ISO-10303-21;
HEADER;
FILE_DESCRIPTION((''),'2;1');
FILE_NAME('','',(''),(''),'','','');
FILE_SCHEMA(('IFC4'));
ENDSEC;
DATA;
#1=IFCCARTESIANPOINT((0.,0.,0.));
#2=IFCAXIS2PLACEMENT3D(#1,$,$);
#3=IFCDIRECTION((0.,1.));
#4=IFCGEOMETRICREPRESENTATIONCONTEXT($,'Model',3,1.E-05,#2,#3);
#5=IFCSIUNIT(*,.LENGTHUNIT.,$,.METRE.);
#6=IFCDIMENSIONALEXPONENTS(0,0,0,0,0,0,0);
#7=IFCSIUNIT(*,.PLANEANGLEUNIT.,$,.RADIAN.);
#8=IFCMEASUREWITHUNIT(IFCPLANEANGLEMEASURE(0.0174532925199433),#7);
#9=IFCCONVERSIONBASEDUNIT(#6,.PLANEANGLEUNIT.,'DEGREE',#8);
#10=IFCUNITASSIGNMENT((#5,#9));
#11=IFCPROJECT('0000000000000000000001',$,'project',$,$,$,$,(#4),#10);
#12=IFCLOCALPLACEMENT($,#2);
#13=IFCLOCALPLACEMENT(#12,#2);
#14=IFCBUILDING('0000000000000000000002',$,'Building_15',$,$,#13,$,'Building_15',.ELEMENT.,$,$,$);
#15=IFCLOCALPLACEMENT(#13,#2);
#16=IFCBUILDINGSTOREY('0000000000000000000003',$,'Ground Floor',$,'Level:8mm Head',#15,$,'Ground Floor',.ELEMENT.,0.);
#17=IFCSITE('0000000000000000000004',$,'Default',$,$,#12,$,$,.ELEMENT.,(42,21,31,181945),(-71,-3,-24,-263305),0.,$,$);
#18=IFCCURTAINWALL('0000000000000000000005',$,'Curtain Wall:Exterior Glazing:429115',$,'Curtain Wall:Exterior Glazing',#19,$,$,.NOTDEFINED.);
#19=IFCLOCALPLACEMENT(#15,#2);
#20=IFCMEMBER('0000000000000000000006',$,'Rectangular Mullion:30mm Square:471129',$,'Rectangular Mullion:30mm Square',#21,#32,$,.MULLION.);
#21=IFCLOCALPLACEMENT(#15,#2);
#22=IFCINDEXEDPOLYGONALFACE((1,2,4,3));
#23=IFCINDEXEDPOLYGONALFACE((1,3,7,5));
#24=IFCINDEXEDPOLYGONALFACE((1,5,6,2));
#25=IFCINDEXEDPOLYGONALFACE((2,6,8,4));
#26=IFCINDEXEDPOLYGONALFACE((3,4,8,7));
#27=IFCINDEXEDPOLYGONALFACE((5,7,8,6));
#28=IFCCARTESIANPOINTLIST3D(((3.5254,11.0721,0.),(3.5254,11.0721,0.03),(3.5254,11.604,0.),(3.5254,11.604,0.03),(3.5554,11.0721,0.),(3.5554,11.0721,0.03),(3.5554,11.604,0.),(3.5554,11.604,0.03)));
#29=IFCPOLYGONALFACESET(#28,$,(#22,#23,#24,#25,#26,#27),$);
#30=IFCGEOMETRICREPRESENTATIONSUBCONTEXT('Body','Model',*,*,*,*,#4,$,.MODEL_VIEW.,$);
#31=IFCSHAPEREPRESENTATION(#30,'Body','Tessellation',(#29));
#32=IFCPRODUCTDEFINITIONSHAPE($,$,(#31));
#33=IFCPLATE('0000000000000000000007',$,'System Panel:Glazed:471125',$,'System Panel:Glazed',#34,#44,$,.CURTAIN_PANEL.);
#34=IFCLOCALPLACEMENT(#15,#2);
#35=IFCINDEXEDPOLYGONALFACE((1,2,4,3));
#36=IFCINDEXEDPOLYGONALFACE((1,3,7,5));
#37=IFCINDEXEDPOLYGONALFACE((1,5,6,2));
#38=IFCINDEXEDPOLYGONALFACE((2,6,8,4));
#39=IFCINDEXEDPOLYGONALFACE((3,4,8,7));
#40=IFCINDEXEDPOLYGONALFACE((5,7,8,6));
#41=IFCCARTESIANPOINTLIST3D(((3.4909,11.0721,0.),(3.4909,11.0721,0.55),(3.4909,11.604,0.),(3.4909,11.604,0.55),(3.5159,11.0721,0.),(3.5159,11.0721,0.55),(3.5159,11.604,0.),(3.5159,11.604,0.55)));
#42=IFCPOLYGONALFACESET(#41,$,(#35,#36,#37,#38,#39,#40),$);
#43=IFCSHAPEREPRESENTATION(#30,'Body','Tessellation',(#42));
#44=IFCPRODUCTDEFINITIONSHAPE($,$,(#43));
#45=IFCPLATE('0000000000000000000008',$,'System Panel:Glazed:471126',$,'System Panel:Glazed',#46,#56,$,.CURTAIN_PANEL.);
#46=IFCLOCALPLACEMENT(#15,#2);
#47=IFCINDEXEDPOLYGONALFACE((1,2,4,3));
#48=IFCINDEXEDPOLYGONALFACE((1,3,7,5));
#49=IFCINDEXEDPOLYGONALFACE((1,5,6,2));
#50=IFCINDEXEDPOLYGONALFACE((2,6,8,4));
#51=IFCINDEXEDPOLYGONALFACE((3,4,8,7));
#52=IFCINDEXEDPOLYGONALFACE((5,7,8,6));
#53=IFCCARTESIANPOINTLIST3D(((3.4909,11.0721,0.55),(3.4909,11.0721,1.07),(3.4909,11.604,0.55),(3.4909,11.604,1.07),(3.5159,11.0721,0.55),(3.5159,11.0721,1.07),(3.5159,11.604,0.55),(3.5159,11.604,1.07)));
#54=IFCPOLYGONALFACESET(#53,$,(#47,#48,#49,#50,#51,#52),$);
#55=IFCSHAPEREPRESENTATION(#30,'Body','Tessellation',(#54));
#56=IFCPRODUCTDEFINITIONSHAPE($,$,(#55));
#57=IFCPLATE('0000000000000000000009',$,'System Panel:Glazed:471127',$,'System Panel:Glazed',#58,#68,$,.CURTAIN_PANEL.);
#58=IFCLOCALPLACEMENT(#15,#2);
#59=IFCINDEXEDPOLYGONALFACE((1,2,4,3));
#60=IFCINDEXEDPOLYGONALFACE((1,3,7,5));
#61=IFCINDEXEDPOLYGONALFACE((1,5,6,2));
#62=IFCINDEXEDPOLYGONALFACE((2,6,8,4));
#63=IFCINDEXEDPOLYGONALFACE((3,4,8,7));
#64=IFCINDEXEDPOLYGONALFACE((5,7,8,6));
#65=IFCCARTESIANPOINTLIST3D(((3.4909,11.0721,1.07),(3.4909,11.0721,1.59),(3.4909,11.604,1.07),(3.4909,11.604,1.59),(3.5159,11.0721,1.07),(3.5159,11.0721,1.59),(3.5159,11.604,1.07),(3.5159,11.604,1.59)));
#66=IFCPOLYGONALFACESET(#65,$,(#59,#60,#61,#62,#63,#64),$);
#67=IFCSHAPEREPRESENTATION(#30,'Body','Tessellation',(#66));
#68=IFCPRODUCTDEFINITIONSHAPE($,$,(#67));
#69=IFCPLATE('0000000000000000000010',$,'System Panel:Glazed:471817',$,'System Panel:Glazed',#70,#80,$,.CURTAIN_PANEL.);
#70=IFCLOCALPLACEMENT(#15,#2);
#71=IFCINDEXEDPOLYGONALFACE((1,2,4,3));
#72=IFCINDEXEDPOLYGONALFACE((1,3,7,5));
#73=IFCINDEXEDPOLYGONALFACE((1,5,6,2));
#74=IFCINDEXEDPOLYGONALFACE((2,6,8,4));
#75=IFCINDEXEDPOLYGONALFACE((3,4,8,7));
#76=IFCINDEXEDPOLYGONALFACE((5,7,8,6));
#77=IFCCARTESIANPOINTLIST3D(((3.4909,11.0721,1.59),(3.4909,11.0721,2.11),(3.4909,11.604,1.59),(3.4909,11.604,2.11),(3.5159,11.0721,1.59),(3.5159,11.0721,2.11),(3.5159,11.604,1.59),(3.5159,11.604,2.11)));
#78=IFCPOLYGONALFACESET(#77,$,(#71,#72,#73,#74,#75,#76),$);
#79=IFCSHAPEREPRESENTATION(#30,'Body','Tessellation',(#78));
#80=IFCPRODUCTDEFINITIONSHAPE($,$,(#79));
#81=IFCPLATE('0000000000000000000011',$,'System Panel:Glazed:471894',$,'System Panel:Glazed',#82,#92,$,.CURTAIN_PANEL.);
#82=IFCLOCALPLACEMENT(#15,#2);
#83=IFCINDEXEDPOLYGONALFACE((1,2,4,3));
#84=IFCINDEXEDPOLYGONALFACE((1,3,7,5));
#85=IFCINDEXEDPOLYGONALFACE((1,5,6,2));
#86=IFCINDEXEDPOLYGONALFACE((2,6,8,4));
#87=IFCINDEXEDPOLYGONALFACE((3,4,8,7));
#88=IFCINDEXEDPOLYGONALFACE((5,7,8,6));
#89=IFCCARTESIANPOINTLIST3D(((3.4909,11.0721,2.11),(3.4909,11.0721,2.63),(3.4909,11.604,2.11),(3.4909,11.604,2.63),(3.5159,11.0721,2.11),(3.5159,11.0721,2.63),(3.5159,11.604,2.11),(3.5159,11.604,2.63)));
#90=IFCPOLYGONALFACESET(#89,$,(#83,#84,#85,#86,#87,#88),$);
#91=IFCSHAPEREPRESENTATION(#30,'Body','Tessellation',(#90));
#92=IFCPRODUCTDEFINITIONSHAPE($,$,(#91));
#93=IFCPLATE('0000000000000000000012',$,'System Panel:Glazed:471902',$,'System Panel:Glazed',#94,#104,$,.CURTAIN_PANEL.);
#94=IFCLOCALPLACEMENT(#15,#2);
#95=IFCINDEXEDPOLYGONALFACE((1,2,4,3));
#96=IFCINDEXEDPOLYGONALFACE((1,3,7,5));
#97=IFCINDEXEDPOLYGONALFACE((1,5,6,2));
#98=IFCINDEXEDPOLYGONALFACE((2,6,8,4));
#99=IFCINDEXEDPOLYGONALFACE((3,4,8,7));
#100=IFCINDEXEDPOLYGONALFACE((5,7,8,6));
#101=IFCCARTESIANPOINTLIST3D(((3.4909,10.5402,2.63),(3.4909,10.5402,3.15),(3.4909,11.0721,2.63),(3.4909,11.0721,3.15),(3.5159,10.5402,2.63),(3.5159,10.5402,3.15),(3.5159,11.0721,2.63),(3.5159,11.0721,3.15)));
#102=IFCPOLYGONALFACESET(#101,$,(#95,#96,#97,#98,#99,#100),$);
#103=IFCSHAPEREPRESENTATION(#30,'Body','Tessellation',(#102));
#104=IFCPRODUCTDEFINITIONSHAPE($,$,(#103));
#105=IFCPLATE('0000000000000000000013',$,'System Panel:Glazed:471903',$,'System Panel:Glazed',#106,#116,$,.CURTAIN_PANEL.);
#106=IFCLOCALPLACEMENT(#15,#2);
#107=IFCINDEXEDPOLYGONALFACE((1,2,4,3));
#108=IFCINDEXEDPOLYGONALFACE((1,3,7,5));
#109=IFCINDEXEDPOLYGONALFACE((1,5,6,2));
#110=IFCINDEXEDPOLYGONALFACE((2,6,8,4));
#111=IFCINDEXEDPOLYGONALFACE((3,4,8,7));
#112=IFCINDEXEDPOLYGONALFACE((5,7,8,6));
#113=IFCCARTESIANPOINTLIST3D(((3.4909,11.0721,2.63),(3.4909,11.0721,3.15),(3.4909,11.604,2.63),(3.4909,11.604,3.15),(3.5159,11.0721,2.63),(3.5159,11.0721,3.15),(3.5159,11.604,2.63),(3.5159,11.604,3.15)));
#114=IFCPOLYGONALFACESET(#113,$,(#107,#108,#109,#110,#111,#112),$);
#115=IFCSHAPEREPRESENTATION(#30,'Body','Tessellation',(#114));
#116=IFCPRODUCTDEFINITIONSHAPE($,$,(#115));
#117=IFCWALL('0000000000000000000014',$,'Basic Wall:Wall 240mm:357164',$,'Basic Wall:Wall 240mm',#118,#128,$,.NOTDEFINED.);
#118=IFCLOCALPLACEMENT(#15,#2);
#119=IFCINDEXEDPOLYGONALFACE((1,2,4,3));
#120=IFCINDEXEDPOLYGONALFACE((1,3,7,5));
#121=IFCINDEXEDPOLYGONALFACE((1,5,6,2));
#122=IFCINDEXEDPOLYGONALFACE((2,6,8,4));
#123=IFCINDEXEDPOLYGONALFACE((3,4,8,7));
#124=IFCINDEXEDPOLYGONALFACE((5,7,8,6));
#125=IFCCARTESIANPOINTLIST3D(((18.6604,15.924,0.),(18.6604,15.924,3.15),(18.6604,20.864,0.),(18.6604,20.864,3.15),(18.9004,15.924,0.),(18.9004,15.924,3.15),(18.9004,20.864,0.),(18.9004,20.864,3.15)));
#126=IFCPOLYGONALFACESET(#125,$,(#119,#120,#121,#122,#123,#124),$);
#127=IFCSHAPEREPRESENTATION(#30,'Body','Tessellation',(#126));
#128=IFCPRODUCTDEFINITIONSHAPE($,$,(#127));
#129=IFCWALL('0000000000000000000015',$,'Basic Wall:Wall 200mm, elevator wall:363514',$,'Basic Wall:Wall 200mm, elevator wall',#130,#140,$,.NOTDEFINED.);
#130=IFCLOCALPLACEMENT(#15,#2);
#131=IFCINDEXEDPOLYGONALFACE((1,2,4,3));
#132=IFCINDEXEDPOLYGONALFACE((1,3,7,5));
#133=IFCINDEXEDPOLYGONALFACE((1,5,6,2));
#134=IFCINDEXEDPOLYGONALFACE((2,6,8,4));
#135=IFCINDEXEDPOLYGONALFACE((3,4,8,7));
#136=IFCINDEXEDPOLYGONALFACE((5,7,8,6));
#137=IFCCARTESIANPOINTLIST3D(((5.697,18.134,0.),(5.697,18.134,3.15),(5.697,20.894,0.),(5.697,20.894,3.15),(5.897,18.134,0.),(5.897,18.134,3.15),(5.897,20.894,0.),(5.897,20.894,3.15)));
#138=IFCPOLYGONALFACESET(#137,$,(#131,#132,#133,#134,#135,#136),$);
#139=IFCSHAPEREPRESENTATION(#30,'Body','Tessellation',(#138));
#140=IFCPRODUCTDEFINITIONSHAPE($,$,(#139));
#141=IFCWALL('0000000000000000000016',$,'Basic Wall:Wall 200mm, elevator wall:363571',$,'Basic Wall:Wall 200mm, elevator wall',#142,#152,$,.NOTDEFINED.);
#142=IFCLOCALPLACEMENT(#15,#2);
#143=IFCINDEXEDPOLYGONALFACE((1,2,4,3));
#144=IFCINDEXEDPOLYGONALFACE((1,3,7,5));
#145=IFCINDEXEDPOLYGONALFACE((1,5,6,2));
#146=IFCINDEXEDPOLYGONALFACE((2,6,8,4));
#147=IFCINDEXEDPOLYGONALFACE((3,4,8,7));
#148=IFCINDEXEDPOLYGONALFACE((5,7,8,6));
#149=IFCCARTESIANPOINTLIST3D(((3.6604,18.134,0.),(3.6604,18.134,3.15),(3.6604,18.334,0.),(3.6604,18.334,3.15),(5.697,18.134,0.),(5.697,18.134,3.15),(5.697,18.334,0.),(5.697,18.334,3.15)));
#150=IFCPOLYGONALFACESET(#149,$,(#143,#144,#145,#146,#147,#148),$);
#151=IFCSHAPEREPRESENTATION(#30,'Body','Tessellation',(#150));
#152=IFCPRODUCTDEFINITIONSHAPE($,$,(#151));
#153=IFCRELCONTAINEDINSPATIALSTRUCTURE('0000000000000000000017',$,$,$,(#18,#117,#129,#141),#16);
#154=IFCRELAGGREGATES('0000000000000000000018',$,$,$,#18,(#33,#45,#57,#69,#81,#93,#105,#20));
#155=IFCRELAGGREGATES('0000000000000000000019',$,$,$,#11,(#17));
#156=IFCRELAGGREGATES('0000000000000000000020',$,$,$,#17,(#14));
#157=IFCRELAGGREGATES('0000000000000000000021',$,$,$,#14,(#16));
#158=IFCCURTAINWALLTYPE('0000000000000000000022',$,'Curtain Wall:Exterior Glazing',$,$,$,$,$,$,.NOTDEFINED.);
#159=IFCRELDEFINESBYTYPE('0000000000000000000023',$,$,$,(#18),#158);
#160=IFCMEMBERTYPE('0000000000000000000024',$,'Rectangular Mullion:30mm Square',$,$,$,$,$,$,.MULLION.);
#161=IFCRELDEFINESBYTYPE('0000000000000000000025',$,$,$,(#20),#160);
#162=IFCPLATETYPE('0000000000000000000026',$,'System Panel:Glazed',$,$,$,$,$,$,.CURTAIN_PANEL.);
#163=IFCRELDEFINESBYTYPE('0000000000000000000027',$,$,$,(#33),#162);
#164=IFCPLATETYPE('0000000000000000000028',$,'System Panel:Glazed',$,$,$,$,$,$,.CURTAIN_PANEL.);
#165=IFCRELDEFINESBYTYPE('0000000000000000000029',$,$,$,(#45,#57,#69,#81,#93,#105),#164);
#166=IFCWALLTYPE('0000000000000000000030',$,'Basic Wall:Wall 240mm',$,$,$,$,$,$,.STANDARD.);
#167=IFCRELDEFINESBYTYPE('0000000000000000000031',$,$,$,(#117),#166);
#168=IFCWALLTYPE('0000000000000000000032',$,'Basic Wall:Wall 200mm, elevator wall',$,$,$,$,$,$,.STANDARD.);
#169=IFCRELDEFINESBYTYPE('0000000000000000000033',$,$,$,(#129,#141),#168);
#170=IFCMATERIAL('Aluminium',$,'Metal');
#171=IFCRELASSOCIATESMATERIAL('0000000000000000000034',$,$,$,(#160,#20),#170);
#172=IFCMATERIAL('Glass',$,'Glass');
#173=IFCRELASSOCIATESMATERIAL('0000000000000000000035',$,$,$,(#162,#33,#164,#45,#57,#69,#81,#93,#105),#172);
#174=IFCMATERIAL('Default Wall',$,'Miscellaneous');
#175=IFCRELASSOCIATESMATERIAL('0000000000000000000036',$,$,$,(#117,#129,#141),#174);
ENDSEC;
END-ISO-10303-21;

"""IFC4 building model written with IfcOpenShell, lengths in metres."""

from ifc_helpers import new_model, entity, si_unit, converted_unit, direction, frame, origin, place, context, subcontext, project, spatial, indexed_curve, outline, extrude, source, transform, mapped, material, type_object, type_shapes, element, aggregate, save


model = new_model("IFC4")

# Units and contexts
model_context = context("Model", 3, precision=1e-05, world=origin(), true_north=direction((0.0, 1.0)))
body_context = subcontext(model_context, "Body", "Model", "MODEL_VIEW")
ifc_project = project(units=[si_unit("LENGTHUNIT", "METRE"), converted_unit("PLANEANGLEUNIT", "DEGREE", entity("IfcPlaneAngleMeasure", 0.0174532925199433), si_unit("PLANEANGLEUNIT", "RADIAN"), dimensions=[0, 0, 0, 0, 0, 0, 0])], contexts=[model_context])

# Site, building, storey
site_placement = place(None, origin())
site = spatial("IfcSite", under=ifc_project, at=site_placement, Name="Default", CompositionType="ELEMENT", RefLatitude=(42, 21, 31, 181945), RefLongitude=(-71, -3, -24, -263305), RefElevation=0.0)
building_placement = place(site_placement, origin())
building = spatial("IfcBuilding", under=site, at=building_placement, Name="Building_15", LongName="Building_15", CompositionType="ELEMENT")
storey_placement = place(building_placement, origin())
storey = spatial("IfcBuildingStorey", under=building, at=storey_placement, Name="Ground Floor", ObjectType="Level:8mm Head", LongName="Ground Floor", CompositionType="ELEMENT", Elevation=0.0)

# Curtain wall, member, plates
curtain_wall_type = type_object("IfcCurtainWallType", Name="Curtain Wall:Exterior Glazing", PredefinedType="NOTDEFINED")
curtain_wall_placement = place(storey_placement, origin())
curtain_wall = element("IfcCurtainWall", 1, at=curtain_wall_placement, inside=storey, type_object=curtain_wall_type, Name="Curtain Wall:Exterior Glazing:429115", ObjectType="Curtain Wall:Exterior Glazing", PredefinedType="NOTDEFINED")
ifc_material_1 = material(Name="Aluminium", Category="Metal")
member_type = type_object("IfcMemberType", Name="Rectangular Mullion:30mm Square", PredefinedType="MULLION", material=ifc_material_1)
shared_shape_1 = source(origin(), body_context, "Body", "SweptSolid", [
    extrude(outline(indexed_curve([(-0.015, -0.015), (0.015, -0.015), (0.015, 0.015), (-0.015, 0.015), (-0.015, -0.015)], self_intersect=False)), frame((-0.015, 0.0, -0.5319), z_axis=(0.0, 0.0, 1.0), x_axis=(-1.0, 0.0, 0.0)), (0.0, 0.0, 1.0), 0.5319),
])
type_shapes(member_type, [shared_shape_1])
member_placement = place(curtain_wall_placement, frame((3.5404, 11.0721, 0.0), z_axis=(0.0, -1.0, 0.0), x_axis=(0.0, 0.0, -1.0)))
member = element("IfcMember", 2, at=member_placement, type_object=member_type, material=ifc_material_1, Name="Rectangular Mullion:30mm Square:471129", ObjectType="Rectangular Mullion:30mm Square", PredefinedType="MULLION", context=body_context, shape_type="MappedRepresentation", body=[
    mapped(shared_shape_1, transform((0.0, 0.0, 0.0), scale=1.0)),
])
ifc_material_2 = material(Name="Glass", Category="Glass")
plate_type_1 = type_object("IfcPlateType", Name="System Panel:Glazed", PredefinedType="CURTAIN_PANEL", material=ifc_material_2)
shared_shape_2 = source(origin(), body_context, "Body", "SweptSolid", [
    extrude(outline(indexed_curve([(-0.0125, -0.2659), (0.0125, -0.2659), (0.0125, 0.2659), (-0.0125, 0.2659), (-0.0125, -0.2659)], self_intersect=False)), frame((0.0, 0.037, 0.0), z_axis=(0.0, 0.0, 1.0), x_axis=(0.0, 1.0, 0.0)), (0.0, 0.0, 1.0), 0.55),
])
type_shapes(plate_type_1, [shared_shape_2])
plate_1_placement = place(curtain_wall_placement, frame((3.5404, 11.3381, 0.0), z_axis=(0.0, 0.0, 1.0), x_axis=(0.0, 1.0, 0.0)))
plate_1 = element("IfcPlate", 3, at=plate_1_placement, type_object=plate_type_1, material=ifc_material_2, Name="System Panel:Glazed:471125", ObjectType="System Panel:Glazed", PredefinedType="CURTAIN_PANEL", context=body_context, shape_type="MappedRepresentation", body=[
    mapped(shared_shape_2, transform((0.0, 0.0, 0.0), scale=1.0)),
])
plate_type_2 = type_object("IfcPlateType", Name="System Panel:Glazed", PredefinedType="CURTAIN_PANEL", material=ifc_material_2)
shared_shape_3 = source(origin(), body_context, "Body", "SweptSolid", [
    extrude(outline(indexed_curve([(-0.0125, -0.2659), (0.0125, -0.2659), (0.0125, 0.2659), (-0.0125, 0.2659), (-0.0125, -0.2659)], self_intersect=False)), frame((0.0, 0.037, 0.0), z_axis=(0.0, 0.0, 1.0), x_axis=(0.0, 1.0, 0.0)), (0.0, 0.0, 1.0), 0.52),
])
type_shapes(plate_type_2, [shared_shape_3])
plate_2_placement = place(curtain_wall_placement, frame((3.5404, 11.3381, 0.55), z_axis=(0.0, 0.0, 1.0), x_axis=(0.0, 1.0, 0.0)))
plate_2 = element("IfcPlate", 4, at=plate_2_placement, type_object=plate_type_2, material=ifc_material_2, Name="System Panel:Glazed:471126", ObjectType="System Panel:Glazed", PredefinedType="CURTAIN_PANEL", context=body_context, shape_type="MappedRepresentation", body=[
    mapped(shared_shape_3, transform((0.0, 0.0, 0.0), scale=1.0)),
])
plate_3_placement = place(curtain_wall_placement, frame((3.5404, 11.3381, 1.07), z_axis=(0.0, 0.0, 1.0), x_axis=(0.0, 1.0, 0.0)))
plate_3 = element("IfcPlate", 5, at=plate_3_placement, type_object=plate_type_2, material=ifc_material_2, Name="System Panel:Glazed:471127", ObjectType="System Panel:Glazed", PredefinedType="CURTAIN_PANEL", context=body_context, shape_type="MappedRepresentation", body=[
    mapped(shared_shape_3, transform((0.0, 0.0, 0.0), scale=1.0)),
])
plate_4_placement = place(curtain_wall_placement, frame((3.5404, 11.3381, 1.59), z_axis=(0.0, 0.0, 1.0), x_axis=(0.0, 1.0, 0.0)))
plate_4 = element("IfcPlate", 6, at=plate_4_placement, type_object=plate_type_2, material=ifc_material_2, Name="System Panel:Glazed:471817", ObjectType="System Panel:Glazed", PredefinedType="CURTAIN_PANEL", context=body_context, shape_type="MappedRepresentation", body=[
    mapped(shared_shape_3, transform((0.0, 0.0, 0.0), scale=1.0)),
])
plate_5_placement = place(curtain_wall_placement, frame((3.5404, 11.3381, 2.11), z_axis=(0.0, 0.0, 1.0), x_axis=(0.0, 1.0, 0.0)))
plate_5 = element("IfcPlate", 7, at=plate_5_placement, type_object=plate_type_2, material=ifc_material_2, Name="System Panel:Glazed:471894", ObjectType="System Panel:Glazed", PredefinedType="CURTAIN_PANEL", context=body_context, shape_type="MappedRepresentation", body=[
    mapped(shared_shape_3, transform((0.0, 0.0, 0.0), scale=1.0)),
])
plate_6_placement = place(curtain_wall_placement, frame((3.5404, 10.8062, 2.63), z_axis=(0.0, 0.0, 1.0), x_axis=(0.0, 1.0, 0.0)))
plate_6 = element("IfcPlate", 8, at=plate_6_placement, type_object=plate_type_2, material=ifc_material_2, Name="System Panel:Glazed:471902", ObjectType="System Panel:Glazed", PredefinedType="CURTAIN_PANEL", context=body_context, shape_type="MappedRepresentation", body=[
    mapped(shared_shape_3, transform((0.0, 0.0, 0.0), scale=1.0)),
])
plate_7_placement = place(curtain_wall_placement, frame((3.5404, 11.3381, 2.63), z_axis=(0.0, 0.0, 1.0), x_axis=(0.0, 1.0, 0.0)))
plate_7 = element("IfcPlate", 9, at=plate_7_placement, type_object=plate_type_2, material=ifc_material_2, Name="System Panel:Glazed:471903", ObjectType="System Panel:Glazed", PredefinedType="CURTAIN_PANEL", context=body_context, shape_type="MappedRepresentation", body=[
    mapped(shared_shape_3, transform((0.0, 0.0, 0.0), scale=1.0)),
])
aggregate(curtain_wall, [plate_1, plate_2, plate_3, plate_4, plate_5, plate_6, plate_7, member])

# Walls
ifc_material_3 = material(Name="Default Wall", Category="Miscellaneous")
wall_type_1 = type_object("IfcWallType", Name="Basic Wall:Wall 240mm", PredefinedType="STANDARD")
wall_1_placement = place(storey_placement, frame((18.7804, 20.864, 0.0), z_axis=(0.0, 0.0, 1.0), x_axis=(0.0, -1.0, 0.0)))
element("IfcWall", 10, at=wall_1_placement, inside=storey, type_object=wall_type_1, material=ifc_material_3, Name="Basic Wall:Wall 240mm:357164", ObjectType="Basic Wall:Wall 240mm", PredefinedType="NOTDEFINED", context=body_context, shape_type="SweptSolid", body=[
    extrude(outline(indexed_curve([(4.94, 0.12), (0.0, 0.12), (0.0, -0.12), (4.94, -0.12), (4.94, 0.12)], self_intersect=False)), origin(), (0.0, 0.0, 1.0), 3.15),
])
wall_type_2 = type_object("IfcWallType", Name="Basic Wall:Wall 200mm, elevator wall", PredefinedType="STANDARD")
wall_2_placement = place(storey_placement, frame((5.797, 20.894, 0.0), z_axis=(0.0, 0.0, 1.0), x_axis=(0.0, -1.0, 0.0)))
element("IfcWall", 11, at=wall_2_placement, inside=storey, type_object=wall_type_2, material=ifc_material_3, Name="Basic Wall:Wall 200mm, elevator wall:363514", ObjectType="Basic Wall:Wall 200mm, elevator wall", PredefinedType="NOTDEFINED", context=body_context, shape_type="SweptSolid", body=[
    extrude(outline(indexed_curve([(2.76, 0.1), (0.0, 0.1), (0.0, -0.1), (2.76, -0.1), (2.76, 0.1)], self_intersect=False)), origin(), (0.0, 0.0, 1.0), 3.15),
])
wall_3_placement = place(storey_placement, frame((5.697, 18.234, 0.0), z_axis=(0.0, 0.0, 1.0), x_axis=(-1.0, 0.0, 0.0)))
element("IfcWall", 12, at=wall_3_placement, inside=storey, type_object=wall_type_2, material=ifc_material_3, Name="Basic Wall:Wall 200mm, elevator wall:363571", ObjectType="Basic Wall:Wall 200mm, elevator wall", PredefinedType="NOTDEFINED", context=body_context, shape_type="SweptSolid", body=[
    extrude(outline(indexed_curve([(2.0366, 0.1), (0.0, 0.1), (0.0, -0.1), (2.0366, -0.1), (2.0366, 0.1)], self_intersect=False)), origin(), (0.0, 0.0, 1.0), 3.15),
])

save(model, "model.ifc")
